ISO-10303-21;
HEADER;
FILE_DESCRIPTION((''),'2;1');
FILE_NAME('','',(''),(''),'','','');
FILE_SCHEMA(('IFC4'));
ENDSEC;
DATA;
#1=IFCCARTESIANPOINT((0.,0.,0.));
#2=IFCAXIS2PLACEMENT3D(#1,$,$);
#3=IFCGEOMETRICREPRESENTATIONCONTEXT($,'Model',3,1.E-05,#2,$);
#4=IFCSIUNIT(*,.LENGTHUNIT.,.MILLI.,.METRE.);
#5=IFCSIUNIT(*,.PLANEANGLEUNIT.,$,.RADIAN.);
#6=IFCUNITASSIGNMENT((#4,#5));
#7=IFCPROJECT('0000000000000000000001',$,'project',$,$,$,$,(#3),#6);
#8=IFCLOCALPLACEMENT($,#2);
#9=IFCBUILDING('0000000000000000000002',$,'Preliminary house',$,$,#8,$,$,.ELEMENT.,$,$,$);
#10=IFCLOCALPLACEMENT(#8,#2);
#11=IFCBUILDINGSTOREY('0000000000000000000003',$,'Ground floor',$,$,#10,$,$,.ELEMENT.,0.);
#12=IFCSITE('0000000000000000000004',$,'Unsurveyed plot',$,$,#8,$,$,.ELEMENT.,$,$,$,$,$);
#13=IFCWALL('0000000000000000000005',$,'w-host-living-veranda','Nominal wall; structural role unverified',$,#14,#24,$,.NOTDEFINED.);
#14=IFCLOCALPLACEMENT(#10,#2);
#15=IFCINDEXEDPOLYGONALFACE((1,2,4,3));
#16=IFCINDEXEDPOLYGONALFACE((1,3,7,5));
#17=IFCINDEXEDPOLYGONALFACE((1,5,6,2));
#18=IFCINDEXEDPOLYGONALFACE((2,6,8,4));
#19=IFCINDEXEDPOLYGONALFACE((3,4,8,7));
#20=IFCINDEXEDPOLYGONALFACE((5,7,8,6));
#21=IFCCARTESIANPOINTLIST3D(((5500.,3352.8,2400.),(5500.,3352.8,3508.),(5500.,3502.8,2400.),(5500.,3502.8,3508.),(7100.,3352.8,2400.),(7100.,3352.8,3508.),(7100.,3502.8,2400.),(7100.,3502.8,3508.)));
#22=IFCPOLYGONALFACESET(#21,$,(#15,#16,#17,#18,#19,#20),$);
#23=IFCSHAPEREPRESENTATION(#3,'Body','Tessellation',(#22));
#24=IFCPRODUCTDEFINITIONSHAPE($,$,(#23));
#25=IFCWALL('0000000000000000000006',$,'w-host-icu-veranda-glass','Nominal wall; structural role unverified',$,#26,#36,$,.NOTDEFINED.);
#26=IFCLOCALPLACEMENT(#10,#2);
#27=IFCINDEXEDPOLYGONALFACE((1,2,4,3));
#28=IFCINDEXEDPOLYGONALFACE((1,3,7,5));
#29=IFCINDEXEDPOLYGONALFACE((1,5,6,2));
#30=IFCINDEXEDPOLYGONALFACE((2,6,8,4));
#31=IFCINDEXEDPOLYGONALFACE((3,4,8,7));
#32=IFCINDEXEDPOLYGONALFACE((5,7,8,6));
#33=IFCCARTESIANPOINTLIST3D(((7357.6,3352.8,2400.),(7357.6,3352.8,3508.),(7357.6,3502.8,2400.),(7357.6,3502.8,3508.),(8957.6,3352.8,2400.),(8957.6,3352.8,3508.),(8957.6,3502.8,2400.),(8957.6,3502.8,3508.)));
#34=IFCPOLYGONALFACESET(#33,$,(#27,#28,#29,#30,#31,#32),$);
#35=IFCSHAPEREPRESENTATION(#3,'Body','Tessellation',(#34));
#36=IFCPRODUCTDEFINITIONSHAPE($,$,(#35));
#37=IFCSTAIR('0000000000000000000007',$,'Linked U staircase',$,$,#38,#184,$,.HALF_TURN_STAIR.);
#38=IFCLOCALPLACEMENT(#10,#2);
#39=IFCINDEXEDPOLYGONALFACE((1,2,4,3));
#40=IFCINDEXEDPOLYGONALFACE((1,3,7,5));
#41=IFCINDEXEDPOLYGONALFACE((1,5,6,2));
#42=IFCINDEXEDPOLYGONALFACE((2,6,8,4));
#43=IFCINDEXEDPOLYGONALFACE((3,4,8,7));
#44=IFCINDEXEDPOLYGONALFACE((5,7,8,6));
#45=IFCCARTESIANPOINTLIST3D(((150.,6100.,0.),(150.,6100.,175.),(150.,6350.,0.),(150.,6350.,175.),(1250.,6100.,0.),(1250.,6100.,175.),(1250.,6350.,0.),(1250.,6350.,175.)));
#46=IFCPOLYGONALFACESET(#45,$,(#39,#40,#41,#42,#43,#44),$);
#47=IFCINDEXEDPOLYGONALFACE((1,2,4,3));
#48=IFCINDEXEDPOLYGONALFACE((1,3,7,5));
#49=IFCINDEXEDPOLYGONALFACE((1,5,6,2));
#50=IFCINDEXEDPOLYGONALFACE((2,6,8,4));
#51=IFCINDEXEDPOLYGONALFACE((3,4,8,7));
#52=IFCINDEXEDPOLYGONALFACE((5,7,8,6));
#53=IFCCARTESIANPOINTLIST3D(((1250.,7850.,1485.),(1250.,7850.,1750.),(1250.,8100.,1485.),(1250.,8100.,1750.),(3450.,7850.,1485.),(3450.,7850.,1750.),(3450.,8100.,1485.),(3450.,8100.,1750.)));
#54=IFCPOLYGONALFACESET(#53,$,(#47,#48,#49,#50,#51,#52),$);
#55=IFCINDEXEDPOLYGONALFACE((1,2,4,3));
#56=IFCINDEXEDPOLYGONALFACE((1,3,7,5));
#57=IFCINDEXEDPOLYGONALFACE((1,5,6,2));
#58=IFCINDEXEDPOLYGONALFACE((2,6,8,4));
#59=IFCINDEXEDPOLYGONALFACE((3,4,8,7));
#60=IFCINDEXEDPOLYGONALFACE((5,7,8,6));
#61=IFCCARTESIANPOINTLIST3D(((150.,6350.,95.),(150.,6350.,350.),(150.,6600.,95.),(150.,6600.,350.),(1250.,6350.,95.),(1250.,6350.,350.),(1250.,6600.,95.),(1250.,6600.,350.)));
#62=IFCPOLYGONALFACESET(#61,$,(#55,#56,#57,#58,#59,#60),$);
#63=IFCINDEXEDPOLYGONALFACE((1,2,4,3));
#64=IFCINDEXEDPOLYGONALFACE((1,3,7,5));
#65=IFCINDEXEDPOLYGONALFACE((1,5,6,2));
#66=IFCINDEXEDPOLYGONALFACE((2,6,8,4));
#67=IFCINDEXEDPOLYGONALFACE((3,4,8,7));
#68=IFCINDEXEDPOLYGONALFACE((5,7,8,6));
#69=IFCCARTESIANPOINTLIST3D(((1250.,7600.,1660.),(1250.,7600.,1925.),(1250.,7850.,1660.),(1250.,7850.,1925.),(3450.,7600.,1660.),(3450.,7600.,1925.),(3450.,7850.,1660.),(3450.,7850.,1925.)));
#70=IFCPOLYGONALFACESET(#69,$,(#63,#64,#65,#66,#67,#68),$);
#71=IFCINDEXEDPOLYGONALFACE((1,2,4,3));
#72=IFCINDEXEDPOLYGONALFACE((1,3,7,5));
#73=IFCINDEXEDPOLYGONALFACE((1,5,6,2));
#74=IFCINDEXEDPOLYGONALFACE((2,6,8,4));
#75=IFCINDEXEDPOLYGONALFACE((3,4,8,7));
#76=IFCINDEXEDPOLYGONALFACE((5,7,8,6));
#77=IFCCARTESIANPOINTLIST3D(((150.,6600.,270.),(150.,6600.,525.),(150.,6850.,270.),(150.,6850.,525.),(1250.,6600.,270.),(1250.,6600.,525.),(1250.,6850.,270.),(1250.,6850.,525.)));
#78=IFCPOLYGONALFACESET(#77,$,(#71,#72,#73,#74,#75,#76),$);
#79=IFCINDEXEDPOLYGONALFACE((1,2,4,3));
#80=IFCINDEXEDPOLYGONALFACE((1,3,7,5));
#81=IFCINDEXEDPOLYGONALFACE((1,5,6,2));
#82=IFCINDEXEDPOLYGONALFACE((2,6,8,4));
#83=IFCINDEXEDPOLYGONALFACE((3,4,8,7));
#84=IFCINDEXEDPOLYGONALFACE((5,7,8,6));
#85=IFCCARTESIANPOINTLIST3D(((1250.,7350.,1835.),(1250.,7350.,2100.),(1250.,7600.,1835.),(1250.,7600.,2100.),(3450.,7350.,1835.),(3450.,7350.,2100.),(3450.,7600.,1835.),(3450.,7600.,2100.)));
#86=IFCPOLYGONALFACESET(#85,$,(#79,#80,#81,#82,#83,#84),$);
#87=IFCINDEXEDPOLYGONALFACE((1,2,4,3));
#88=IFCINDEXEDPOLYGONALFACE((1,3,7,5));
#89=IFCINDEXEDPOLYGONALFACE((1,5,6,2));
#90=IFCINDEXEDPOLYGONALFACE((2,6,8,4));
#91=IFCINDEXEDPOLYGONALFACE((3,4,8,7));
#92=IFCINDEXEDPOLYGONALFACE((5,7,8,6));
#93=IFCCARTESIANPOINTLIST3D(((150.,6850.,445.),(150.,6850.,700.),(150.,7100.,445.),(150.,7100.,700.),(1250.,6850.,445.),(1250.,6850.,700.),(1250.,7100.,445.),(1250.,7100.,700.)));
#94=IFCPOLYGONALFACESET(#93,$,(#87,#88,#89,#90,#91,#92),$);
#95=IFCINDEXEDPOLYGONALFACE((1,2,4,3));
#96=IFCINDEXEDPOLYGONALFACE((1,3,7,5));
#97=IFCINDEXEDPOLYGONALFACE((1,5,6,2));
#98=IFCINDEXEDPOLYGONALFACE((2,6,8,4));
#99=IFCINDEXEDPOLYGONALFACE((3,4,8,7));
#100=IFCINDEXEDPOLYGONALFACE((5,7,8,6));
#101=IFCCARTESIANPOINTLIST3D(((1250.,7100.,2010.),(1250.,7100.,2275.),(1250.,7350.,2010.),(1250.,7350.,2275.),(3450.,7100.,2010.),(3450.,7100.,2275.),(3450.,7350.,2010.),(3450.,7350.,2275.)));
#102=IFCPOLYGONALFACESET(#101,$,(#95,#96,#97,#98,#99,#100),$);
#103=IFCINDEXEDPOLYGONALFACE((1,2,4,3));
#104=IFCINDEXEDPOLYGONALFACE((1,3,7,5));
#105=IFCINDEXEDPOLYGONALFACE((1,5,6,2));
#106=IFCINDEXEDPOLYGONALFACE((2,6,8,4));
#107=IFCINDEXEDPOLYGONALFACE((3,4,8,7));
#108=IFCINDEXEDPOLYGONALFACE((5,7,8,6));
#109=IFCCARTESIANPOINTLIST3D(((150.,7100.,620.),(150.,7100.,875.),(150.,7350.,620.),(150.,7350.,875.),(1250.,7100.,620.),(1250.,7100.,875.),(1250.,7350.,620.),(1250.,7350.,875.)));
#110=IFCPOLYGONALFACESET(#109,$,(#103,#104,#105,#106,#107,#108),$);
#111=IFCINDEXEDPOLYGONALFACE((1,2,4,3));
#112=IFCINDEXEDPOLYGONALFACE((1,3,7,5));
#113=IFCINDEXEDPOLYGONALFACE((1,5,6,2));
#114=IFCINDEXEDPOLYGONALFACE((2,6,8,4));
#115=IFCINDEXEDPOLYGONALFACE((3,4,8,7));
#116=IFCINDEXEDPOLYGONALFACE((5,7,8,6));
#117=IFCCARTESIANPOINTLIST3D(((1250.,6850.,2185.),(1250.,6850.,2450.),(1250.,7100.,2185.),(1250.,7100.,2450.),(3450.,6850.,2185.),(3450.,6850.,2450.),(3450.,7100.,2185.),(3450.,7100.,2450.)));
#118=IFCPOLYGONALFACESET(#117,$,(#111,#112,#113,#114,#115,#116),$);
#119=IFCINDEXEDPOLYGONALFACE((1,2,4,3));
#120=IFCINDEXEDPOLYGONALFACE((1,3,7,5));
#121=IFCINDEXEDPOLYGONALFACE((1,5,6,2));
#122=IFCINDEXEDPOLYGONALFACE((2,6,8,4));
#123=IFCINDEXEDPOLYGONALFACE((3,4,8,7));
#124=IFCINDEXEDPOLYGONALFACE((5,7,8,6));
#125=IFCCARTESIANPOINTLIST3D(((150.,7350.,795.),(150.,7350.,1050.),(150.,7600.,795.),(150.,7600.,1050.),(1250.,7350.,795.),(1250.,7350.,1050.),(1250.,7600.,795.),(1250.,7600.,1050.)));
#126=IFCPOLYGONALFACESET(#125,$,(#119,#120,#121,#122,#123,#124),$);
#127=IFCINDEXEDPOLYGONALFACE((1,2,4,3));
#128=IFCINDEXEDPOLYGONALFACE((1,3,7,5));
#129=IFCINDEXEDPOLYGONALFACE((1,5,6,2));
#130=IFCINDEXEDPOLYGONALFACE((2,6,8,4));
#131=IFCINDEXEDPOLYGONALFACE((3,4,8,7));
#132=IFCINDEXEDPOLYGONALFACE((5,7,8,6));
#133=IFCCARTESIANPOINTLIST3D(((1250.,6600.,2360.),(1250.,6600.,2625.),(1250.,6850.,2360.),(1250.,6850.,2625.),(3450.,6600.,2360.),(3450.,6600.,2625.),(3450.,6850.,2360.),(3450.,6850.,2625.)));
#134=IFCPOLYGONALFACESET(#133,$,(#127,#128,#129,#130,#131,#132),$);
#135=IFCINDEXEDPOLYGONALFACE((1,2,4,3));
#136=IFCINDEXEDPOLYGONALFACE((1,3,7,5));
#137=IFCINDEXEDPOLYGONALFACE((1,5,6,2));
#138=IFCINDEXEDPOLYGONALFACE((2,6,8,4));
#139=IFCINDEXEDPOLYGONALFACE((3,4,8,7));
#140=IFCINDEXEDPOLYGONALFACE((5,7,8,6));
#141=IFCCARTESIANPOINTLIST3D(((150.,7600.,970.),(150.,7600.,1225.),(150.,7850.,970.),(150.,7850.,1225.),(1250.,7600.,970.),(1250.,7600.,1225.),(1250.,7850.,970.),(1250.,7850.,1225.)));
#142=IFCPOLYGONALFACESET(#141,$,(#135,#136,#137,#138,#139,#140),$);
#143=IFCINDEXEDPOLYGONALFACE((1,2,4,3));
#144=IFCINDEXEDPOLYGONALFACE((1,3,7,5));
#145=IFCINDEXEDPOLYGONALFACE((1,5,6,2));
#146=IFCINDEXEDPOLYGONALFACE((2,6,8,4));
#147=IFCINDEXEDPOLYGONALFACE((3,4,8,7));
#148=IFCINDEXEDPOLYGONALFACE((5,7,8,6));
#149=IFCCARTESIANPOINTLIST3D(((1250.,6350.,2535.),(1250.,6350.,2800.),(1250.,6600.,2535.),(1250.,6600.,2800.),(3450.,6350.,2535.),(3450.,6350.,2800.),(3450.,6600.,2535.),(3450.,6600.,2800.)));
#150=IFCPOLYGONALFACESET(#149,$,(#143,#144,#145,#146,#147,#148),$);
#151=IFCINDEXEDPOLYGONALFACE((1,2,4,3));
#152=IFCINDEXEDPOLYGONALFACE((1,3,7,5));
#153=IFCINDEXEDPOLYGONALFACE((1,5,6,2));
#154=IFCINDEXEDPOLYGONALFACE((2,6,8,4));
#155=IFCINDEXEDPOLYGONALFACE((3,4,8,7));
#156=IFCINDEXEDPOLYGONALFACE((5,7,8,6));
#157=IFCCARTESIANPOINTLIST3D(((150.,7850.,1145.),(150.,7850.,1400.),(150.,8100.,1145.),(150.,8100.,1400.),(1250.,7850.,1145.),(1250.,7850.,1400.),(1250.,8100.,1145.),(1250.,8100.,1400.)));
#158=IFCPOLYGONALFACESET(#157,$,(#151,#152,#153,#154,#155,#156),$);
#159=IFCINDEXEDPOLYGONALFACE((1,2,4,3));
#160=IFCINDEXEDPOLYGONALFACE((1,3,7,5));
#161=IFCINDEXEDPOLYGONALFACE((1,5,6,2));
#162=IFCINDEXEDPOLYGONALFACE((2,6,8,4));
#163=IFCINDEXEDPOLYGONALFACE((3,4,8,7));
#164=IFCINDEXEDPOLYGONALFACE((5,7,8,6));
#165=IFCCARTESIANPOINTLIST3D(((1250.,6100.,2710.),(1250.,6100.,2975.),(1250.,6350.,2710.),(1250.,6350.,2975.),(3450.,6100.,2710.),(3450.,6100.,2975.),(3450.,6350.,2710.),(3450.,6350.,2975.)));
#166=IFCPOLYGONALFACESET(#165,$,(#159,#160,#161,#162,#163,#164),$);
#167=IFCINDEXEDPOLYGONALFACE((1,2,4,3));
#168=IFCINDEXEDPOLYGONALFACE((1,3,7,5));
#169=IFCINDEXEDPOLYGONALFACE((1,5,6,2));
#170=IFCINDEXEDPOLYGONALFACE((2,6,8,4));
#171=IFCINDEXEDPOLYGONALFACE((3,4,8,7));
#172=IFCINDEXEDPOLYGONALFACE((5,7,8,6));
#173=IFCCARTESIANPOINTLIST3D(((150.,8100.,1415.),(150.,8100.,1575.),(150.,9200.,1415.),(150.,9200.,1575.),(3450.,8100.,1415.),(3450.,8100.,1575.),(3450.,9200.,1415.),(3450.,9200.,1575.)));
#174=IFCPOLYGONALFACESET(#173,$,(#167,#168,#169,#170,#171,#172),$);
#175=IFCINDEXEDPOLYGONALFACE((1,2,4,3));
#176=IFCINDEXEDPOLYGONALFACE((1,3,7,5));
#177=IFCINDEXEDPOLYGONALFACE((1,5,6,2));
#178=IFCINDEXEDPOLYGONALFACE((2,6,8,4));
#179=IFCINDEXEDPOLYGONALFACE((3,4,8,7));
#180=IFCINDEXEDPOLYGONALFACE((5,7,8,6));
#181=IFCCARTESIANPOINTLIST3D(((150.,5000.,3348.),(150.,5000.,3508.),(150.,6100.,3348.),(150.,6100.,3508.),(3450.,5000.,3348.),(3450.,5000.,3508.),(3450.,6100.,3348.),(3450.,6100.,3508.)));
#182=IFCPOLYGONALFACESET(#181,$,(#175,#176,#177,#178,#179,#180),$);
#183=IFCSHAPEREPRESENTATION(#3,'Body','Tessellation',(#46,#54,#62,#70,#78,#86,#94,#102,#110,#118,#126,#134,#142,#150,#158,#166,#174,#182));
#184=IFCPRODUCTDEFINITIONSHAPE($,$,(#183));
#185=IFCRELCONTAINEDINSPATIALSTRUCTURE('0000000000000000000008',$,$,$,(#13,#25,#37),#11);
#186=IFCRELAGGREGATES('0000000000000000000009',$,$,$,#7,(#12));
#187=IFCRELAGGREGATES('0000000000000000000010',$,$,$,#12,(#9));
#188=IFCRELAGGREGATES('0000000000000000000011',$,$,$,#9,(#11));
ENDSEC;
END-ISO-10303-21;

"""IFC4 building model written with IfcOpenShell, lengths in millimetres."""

from ifc_helpers import new_model, si_unit, frame, origin, place, context, project, spatial, polyline, outline, extrude, element, save


model = new_model("IFC4")

# Units and contexts
model_context = context("Model", 3, precision=1e-05, world=origin())
ifc_project = project(units=[si_unit("LENGTHUNIT", "METRE", prefix="MILLI"), si_unit("PLANEANGLEUNIT", "RADIAN")], contexts=[model_context])

# Site, building, storey
placement_1 = place(None, origin())
site = spatial("IfcSite", under=ifc_project, at=placement_1, Name="Unsurveyed plot", CompositionType="ELEMENT")
building = spatial("IfcBuilding", under=site, at=placement_1, Name="Preliminary house", CompositionType="ELEMENT")
placement_2 = place(placement_1, origin())
storey = spatial("IfcBuildingStorey", under=building, at=placement_2, Name="Ground floor", CompositionType="ELEMENT", Elevation=0.0)

# Walls, openings
wall_1 = element("IfcWall", 1, at=placement_2, inside=storey, Name="w-host-living-veranda", Description="Nominal wall; structural role unverified", PredefinedType="NOTDEFINED", context=model_context, shape_type="SweptSolid", body=[
    extrude(outline(polyline([(5500.0, 3352.8), (7100.0, 3352.8), (7100.0, 3502.8), (5500.0, 3502.8), (5500.0, 3352.8)])), origin(), (0.0, 0.0, 1.0), 3508.0),
])
element("IfcOpeningElement", 2, at=placement_2, cuts=wall_1, PredefinedType="OPENING", context=model_context, shape_type="SweptSolid", body=[
    extrude(outline(polyline([(5500.0, 2977.8), (7100.0, 2977.8), (7100.0, 3877.8), (5500.0, 3877.8), (5500.0, 2977.8)])), origin(), (0.0, 0.0, 1.0), 2400.0),
])
wall_2 = element("IfcWall", 3, at=placement_2, inside=storey, Name="w-host-icu-veranda-glass", Description="Nominal wall; structural role unverified", PredefinedType="NOTDEFINED", context=model_context, shape_type="SweptSolid", body=[
    extrude(outline(polyline([(7357.6, 3352.8), (8957.6, 3352.8), (8957.6, 3502.8), (7357.6, 3502.8), (7357.6, 3352.8)])), origin(), (0.0, 0.0, 1.0), 3508.0),
])
element("IfcOpeningElement", 4, at=placement_2, cuts=wall_2, PredefinedType="OPENING", context=model_context, shape_type="SweptSolid", body=[
    extrude(outline(polyline([(7357.6, 2977.8), (8957.6, 2977.8), (8957.6, 3877.8), (7357.6, 3877.8), (7357.6, 2977.8)])), origin(), (0.0, 0.0, 1.0), 2400.0),
])

# Stair
element("IfcStair", 5, at=placement_2, inside=storey, Name="Linked U staircase", PredefinedType="HALF_TURN_STAIR", context=model_context, shape_type="SweptSolid", body=[
    extrude(outline(polyline([(1250.0, 6100.0), (1250.0, 6350.0), (150.0, 6350.0), (150.0, 6100.0), (1250.0, 6100.0)])), origin(), (0.0, 0.0, 1.0), 175.0),
    extrude(outline(polyline([(3450.0, 7850.0), (3450.0, 8100.0), (1250.0, 8100.0), (1250.0, 7850.0), (3450.0, 7850.0)])), frame((0.0, 0.0, 1485.0)), (0.0, 0.0, 1.0), 265.0),
    extrude(outline(polyline([(1250.0, 6350.0), (1250.0, 6600.0), (150.0, 6600.0), (150.0, 6350.0), (1250.0, 6350.0)])), frame((0.0, 0.0, 95.0)), (0.0, 0.0, 1.0), 255.0),
    extrude(outline(polyline([(3450.0, 7600.0), (3450.0, 7850.0), (1250.0, 7850.0), (1250.0, 7600.0), (3450.0, 7600.0)])), frame((0.0, 0.0, 1660.0)), (0.0, 0.0, 1.0), 265.0),
    extrude(outline(polyline([(1250.0, 6600.0), (1250.0, 6850.0), (150.0, 6850.0), (150.0, 6600.0), (1250.0, 6600.0)])), frame((0.0, 0.0, 270.0)), (0.0, 0.0, 1.0), 255.0),
    extrude(outline(polyline([(3450.0, 7350.0), (3450.0, 7600.0), (1250.0, 7600.0), (1250.0, 7350.0), (3450.0, 7350.0)])), frame((0.0, 0.0, 1835.0)), (0.0, 0.0, 1.0), 265.0),
    extrude(outline(polyline([(1250.0, 6850.0), (1250.0, 7100.0), (150.0, 7100.0), (150.0, 6850.0), (1250.0, 6850.0)])), frame((0.0, 0.0, 445.0)), (0.0, 0.0, 1.0), 255.0),
    extrude(outline(polyline([(3450.0, 7100.0), (3450.0, 7350.0), (1250.0, 7350.0), (1250.0, 7100.0), (3450.0, 7100.0)])), frame((0.0, 0.0, 2010.0)), (0.0, 0.0, 1.0), 265.0),
    extrude(outline(polyline([(1250.0, 7100.0), (1250.0, 7350.0), (150.0, 7350.0), (150.0, 7100.0), (1250.0, 7100.0)])), frame((0.0, 0.0, 620.0)), (0.0, 0.0, 1.0), 255.0),
    extrude(outline(polyline([(3450.0, 6850.0), (3450.0, 7100.0), (1250.0, 7100.0), (1250.0, 6850.0), (3450.0, 6850.0)])), frame((0.0, 0.0, 2185.0)), (0.0, 0.0, 1.0), 265.0),
    extrude(outline(polyline([(1250.0, 7350.0), (1250.0, 7600.0), (150.0, 7600.0), (150.0, 7350.0), (1250.0, 7350.0)])), frame((0.0, 0.0, 795.0)), (0.0, 0.0, 1.0), 255.0),
    extrude(outline(polyline([(3450.0, 6600.0), (3450.0, 6850.0), (1250.0, 6850.0), (1250.0, 6600.0), (3450.0, 6600.0)])), frame((0.0, 0.0, 2360.0)), (0.0, 0.0, 1.0), 265.0),
    extrude(outline(polyline([(1250.0, 7600.0), (1250.0, 7850.0), (150.0, 7850.0), (150.0, 7600.0), (1250.0, 7600.0)])), frame((0.0, 0.0, 970.0)), (0.0, 0.0, 1.0), 255.0),
    extrude(outline(polyline([(3450.0, 6350.0), (3450.0, 6600.0), (1250.0, 6600.0), (1250.0, 6350.0), (3450.0, 6350.0)])), frame((0.0, 0.0, 2535.0)), (0.0, 0.0, 1.0), 265.0),
    extrude(outline(polyline([(1250.0, 7850.0), (1250.0, 8100.0), (150.0, 8100.0), (150.0, 7850.0), (1250.0, 7850.0)])), frame((0.0, 0.0, 1145.0)), (0.0, 0.0, 1.0), 255.0),
    extrude(outline(polyline([(3450.0, 6100.0), (3450.0, 6350.0), (1250.0, 6350.0), (1250.0, 6100.0), (3450.0, 6100.0)])), frame((0.0, 0.0, 2710.0)), (0.0, 0.0, 1.0), 265.0),
    extrude(outline(polyline([(3450.0, 8100.0), (3450.0, 9200.0), (150.0, 9200.0), (150.0, 8100.0), (3450.0, 8100.0)])), frame((0.0, 0.0, 1415.0)), (0.0, 0.0, 1.0), 160.0),
    extrude(outline(polyline([(3450.0, 5000.0), (3450.0, 6100.0), (150.0, 6100.0), (150.0, 5000.0), (3450.0, 5000.0)])), frame((0.0, 0.0, 3348.0)), (0.0, 0.0, 1.0), 160.0),
])

save(model, "model.ifc")
